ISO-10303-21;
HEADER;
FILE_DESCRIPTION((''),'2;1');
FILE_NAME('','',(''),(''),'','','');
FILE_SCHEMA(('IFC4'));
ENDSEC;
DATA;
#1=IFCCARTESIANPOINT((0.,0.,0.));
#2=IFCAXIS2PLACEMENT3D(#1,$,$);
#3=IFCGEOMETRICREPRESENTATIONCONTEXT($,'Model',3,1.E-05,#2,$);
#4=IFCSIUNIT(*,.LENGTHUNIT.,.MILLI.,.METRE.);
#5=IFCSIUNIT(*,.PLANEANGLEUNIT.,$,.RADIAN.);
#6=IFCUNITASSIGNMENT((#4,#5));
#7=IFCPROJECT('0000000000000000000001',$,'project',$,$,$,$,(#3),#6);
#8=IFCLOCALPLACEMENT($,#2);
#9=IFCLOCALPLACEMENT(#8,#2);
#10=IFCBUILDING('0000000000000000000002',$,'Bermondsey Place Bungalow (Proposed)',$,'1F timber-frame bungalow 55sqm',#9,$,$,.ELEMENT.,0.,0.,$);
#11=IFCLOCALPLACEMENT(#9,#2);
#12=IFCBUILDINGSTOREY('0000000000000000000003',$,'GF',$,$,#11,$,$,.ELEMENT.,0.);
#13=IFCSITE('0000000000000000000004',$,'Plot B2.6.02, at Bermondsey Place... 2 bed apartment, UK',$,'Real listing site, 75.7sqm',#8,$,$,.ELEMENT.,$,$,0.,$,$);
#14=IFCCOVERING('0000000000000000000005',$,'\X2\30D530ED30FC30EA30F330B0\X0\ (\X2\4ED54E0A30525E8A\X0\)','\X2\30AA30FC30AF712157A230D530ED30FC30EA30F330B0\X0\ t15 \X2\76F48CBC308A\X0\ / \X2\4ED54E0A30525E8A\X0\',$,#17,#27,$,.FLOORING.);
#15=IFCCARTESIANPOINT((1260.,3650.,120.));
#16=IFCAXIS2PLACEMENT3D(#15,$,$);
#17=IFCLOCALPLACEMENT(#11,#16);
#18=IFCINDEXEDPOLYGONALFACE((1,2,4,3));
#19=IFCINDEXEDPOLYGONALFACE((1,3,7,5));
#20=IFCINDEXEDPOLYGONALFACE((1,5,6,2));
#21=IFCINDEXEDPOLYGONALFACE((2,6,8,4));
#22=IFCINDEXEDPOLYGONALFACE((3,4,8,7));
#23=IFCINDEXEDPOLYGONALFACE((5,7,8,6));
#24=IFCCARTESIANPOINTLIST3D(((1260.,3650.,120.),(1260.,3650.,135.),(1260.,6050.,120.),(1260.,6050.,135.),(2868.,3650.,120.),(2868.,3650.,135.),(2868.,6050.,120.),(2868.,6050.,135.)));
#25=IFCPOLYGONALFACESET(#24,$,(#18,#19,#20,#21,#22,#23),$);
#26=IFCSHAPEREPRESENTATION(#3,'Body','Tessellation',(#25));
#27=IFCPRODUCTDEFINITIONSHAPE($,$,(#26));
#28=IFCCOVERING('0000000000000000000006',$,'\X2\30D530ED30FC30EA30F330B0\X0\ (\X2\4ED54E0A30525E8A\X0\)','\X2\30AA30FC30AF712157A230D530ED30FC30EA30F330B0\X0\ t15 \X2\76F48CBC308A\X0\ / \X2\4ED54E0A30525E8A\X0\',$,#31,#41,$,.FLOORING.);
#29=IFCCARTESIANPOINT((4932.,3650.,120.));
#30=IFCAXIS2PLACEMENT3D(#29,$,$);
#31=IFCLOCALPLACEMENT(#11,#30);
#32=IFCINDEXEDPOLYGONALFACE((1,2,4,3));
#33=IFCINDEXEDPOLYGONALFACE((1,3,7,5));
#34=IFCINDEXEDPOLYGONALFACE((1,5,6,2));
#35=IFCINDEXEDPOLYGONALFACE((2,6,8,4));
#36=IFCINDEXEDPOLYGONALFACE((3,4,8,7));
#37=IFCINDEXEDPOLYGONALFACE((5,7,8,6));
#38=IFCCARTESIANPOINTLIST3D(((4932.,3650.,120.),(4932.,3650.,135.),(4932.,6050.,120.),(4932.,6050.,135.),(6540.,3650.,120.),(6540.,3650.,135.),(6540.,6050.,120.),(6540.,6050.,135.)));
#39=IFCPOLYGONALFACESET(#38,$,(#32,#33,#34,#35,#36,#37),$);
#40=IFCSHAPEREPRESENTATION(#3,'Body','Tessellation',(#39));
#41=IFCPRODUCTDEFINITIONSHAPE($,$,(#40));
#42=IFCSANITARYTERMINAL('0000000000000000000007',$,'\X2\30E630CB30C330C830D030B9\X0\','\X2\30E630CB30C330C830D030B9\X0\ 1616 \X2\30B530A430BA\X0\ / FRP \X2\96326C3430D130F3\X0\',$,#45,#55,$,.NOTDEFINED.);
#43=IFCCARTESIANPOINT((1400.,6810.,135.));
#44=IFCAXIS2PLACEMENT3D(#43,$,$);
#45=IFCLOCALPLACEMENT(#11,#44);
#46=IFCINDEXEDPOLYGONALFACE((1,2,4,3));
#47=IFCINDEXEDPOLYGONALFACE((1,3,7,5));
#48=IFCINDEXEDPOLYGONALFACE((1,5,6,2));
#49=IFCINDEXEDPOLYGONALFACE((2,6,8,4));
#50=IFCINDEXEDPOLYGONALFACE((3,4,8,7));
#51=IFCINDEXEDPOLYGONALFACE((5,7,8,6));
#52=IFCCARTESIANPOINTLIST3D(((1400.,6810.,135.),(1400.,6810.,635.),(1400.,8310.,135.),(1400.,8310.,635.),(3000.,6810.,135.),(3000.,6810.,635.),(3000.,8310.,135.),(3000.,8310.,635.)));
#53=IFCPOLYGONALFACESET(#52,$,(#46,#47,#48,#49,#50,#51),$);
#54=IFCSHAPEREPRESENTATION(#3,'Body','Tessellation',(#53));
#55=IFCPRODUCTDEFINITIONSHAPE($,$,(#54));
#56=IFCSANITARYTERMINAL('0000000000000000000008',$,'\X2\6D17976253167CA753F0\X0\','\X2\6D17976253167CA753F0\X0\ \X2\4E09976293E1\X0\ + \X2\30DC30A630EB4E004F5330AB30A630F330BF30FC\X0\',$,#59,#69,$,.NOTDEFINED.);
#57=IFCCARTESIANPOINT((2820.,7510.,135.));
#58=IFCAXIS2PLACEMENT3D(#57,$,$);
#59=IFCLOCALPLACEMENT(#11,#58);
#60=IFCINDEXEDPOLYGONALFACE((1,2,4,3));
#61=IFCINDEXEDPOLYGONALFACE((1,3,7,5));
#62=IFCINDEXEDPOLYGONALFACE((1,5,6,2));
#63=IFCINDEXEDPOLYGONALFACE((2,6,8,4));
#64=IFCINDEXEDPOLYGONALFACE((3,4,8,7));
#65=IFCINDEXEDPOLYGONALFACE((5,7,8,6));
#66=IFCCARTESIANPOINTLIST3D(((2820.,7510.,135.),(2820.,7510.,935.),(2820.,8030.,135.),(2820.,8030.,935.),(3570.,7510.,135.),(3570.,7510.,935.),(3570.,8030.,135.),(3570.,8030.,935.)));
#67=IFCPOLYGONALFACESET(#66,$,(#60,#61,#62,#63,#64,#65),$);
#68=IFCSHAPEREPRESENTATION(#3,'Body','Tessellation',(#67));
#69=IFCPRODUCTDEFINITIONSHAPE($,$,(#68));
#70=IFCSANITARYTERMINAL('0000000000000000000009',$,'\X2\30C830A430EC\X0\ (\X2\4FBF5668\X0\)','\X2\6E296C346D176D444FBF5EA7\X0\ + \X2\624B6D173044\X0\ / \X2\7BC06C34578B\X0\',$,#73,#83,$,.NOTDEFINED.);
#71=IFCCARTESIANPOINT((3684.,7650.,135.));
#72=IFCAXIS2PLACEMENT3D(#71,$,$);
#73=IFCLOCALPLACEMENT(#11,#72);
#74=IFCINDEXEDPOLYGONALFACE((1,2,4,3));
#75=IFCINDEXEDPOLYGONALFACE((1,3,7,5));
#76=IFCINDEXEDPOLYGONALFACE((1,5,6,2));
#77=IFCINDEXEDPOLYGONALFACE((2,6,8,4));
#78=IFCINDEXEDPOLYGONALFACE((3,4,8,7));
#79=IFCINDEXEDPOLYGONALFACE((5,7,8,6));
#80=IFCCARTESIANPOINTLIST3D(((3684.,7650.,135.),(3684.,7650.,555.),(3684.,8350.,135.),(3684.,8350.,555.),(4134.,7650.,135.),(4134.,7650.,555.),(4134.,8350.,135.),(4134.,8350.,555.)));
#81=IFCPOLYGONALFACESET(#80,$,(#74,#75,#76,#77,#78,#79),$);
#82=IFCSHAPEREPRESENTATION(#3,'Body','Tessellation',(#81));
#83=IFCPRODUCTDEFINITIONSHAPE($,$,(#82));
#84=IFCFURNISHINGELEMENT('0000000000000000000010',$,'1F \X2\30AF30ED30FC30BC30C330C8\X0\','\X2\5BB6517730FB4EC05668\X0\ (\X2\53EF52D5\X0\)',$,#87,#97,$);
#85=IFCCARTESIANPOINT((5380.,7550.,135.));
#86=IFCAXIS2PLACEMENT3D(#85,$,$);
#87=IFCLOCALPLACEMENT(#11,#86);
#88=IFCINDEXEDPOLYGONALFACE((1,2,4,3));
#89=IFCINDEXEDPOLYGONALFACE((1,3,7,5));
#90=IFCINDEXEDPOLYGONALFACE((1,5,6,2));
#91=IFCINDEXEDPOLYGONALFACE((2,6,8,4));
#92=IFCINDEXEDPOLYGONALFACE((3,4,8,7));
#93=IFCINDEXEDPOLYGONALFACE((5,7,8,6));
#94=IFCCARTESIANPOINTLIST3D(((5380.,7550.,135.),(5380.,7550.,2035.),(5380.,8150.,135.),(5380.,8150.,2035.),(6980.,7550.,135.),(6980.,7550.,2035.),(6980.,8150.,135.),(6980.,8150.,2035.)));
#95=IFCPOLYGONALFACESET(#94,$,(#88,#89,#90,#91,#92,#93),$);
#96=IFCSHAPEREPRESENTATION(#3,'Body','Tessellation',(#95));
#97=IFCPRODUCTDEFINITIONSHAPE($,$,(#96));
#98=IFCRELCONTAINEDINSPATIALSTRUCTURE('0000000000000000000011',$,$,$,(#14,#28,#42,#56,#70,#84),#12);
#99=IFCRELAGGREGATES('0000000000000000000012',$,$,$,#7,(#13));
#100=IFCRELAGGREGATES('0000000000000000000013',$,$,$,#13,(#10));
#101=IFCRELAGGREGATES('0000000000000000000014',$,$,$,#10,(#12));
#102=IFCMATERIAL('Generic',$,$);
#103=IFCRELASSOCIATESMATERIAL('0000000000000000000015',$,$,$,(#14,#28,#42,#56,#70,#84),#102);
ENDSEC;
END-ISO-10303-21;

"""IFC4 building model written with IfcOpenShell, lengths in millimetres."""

from ifc_helpers import new_model, si_unit, frame, frame_2d, origin, place, context, project, spatial, rectangle, extrude, material, element, save


model = new_model("IFC4")

# Units and contexts
model_context = context("Model", 3, precision=1e-05, world=origin())
ifc_project = project(units=[si_unit("LENGTHUNIT", "METRE", prefix="MILLI"), si_unit("PLANEANGLEUNIT", "RADIAN")], contexts=[model_context])

# Site, building, storey
site_placement = place(None, origin())
site = spatial("IfcSite", under=ifc_project, at=site_placement, Name="Plot B2.6.02, at Bermondsey Place... 2 bed apartment, UK", ObjectType="Real listing site, 75.7sqm", CompositionType="ELEMENT", RefElevation=0.0)
building_placement = place(site_placement, origin())
building = spatial("IfcBuilding", under=site, at=building_placement, Name="Bermondsey Place Bungalow (Proposed)", ObjectType="1F timber-frame bungalow 55sqm", CompositionType="ELEMENT", ElevationOfRefHeight=0.0, ElevationOfTerrain=0.0)
storey_placement = place(building_placement, origin())
storey = spatial("IfcBuildingStorey", under=building, at=storey_placement, Name="GF", CompositionType="ELEMENT", Elevation=0.0)

# Coverings
ifc_material_1 = material(Name="Generic")
covering_1_placement = place(storey_placement, frame((1260.0, 3650.0, 120.0)))
element("IfcCovering", 1, at=covering_1_placement, inside=storey, material=ifc_material_1, Name="フローリング (仕上げ床)", Description="オーク無垢フローリング t15 直貼り / 仕上げ床", PredefinedType="FLOORING", context=model_context, shape_type="SweptSolid", body=[
    extrude(rectangle(XDim=1608.0, YDim=2400.0, at=frame_2d((804.0, 1200.0))), frame((1260.0, 3650.0, 120.0)), (0.0, 0.0, 1.0), 15.0),
])
covering_2_placement = place(storey_placement, frame((4932.0, 3650.0, 120.0)))
element("IfcCovering", 2, at=covering_2_placement, inside=storey, material=ifc_material_1, Name="フローリング (仕上げ床)", Description="オーク無垢フローリング t15 直貼り / 仕上げ床", PredefinedType="FLOORING", context=model_context, shape_type="SweptSolid", body=[
    extrude(rectangle(XDim=1608.0, YDim=2400.0, at=frame_2d((804.0, 1200.0))), frame((4932.0, 3650.0, 120.0)), (0.0, 0.0, 1.0), 15.0),
])

# Sanitary terminals
sanitary_terminal_1_placement = place(storey_placement, frame((1400.0, 6810.0, 135.0)))
element("IfcSanitaryTerminal", 3, at=sanitary_terminal_1_placement, inside=storey, material=ifc_material_1, Name="ユニットバス", Description="ユニットバス 1616 サイズ / FRP 防水パン", PredefinedType="NOTDEFINED", context=model_context, shape_type="SweptSolid", body=[
    extrude(rectangle(XDim=1600.0, YDim=1500.0, at=frame_2d((800.0, 750.0))), frame((1400.0, 6810.0, 135.0)), (0.0, 0.0, 1.0), 500.0),
])
sanitary_terminal_2_placement = place(storey_placement, frame((2820.0, 7510.0, 135.0)))
element("IfcSanitaryTerminal", 4, at=sanitary_terminal_2_placement, inside=storey, material=ifc_material_1, Name="洗面化粧台", Description="洗面化粧台 三面鏡 + ボウル一体カウンター", PredefinedType="NOTDEFINED", context=model_context, shape_type="SweptSolid", body=[
    extrude(rectangle(XDim=750.0, YDim=520.0, at=frame_2d((375.0, 260.0))), frame((2820.0, 7510.0, 135.0)), (0.0, 0.0, 1.0), 800.0),
])
sanitary_terminal_3_placement = place(storey_placement, frame((3684.0, 7650.0, 135.0)))
element("IfcSanitaryTerminal", 5, at=sanitary_terminal_3_placement, inside=storey, material=ifc_material_1, Name="トイレ (便器)", Description="温水洗浄便座 + 手洗い / 節水型", PredefinedType="NOTDEFINED", context=model_context, shape_type="SweptSolid", body=[
    extrude(rectangle(XDim=450.0, YDim=700.0, at=frame_2d((225.0, 350.0))), frame((3684.0, 7650.0, 135.0)), (0.0, 0.0, 1.0), 420.0),
])

# Furnishing element
furnishing_placement = place(storey_placement, frame((5380.0, 7550.0, 135.0)))
element("IfcFurnishingElement", 6, at=furnishing_placement, inside=storey, material=ifc_material_1, Name="1F クローゼット", Description="家具・什器 (可動)", context=model_context, shape_type="SweptSolid", body=[
    extrude(rectangle(XDim=1600.0, YDim=600.0, at=frame_2d((800.0, 300.0))), frame((5380.0, 7550.0, 135.0)), (0.0, 0.0, 1.0), 1900.0),
])

save(model, "model.ifc")
